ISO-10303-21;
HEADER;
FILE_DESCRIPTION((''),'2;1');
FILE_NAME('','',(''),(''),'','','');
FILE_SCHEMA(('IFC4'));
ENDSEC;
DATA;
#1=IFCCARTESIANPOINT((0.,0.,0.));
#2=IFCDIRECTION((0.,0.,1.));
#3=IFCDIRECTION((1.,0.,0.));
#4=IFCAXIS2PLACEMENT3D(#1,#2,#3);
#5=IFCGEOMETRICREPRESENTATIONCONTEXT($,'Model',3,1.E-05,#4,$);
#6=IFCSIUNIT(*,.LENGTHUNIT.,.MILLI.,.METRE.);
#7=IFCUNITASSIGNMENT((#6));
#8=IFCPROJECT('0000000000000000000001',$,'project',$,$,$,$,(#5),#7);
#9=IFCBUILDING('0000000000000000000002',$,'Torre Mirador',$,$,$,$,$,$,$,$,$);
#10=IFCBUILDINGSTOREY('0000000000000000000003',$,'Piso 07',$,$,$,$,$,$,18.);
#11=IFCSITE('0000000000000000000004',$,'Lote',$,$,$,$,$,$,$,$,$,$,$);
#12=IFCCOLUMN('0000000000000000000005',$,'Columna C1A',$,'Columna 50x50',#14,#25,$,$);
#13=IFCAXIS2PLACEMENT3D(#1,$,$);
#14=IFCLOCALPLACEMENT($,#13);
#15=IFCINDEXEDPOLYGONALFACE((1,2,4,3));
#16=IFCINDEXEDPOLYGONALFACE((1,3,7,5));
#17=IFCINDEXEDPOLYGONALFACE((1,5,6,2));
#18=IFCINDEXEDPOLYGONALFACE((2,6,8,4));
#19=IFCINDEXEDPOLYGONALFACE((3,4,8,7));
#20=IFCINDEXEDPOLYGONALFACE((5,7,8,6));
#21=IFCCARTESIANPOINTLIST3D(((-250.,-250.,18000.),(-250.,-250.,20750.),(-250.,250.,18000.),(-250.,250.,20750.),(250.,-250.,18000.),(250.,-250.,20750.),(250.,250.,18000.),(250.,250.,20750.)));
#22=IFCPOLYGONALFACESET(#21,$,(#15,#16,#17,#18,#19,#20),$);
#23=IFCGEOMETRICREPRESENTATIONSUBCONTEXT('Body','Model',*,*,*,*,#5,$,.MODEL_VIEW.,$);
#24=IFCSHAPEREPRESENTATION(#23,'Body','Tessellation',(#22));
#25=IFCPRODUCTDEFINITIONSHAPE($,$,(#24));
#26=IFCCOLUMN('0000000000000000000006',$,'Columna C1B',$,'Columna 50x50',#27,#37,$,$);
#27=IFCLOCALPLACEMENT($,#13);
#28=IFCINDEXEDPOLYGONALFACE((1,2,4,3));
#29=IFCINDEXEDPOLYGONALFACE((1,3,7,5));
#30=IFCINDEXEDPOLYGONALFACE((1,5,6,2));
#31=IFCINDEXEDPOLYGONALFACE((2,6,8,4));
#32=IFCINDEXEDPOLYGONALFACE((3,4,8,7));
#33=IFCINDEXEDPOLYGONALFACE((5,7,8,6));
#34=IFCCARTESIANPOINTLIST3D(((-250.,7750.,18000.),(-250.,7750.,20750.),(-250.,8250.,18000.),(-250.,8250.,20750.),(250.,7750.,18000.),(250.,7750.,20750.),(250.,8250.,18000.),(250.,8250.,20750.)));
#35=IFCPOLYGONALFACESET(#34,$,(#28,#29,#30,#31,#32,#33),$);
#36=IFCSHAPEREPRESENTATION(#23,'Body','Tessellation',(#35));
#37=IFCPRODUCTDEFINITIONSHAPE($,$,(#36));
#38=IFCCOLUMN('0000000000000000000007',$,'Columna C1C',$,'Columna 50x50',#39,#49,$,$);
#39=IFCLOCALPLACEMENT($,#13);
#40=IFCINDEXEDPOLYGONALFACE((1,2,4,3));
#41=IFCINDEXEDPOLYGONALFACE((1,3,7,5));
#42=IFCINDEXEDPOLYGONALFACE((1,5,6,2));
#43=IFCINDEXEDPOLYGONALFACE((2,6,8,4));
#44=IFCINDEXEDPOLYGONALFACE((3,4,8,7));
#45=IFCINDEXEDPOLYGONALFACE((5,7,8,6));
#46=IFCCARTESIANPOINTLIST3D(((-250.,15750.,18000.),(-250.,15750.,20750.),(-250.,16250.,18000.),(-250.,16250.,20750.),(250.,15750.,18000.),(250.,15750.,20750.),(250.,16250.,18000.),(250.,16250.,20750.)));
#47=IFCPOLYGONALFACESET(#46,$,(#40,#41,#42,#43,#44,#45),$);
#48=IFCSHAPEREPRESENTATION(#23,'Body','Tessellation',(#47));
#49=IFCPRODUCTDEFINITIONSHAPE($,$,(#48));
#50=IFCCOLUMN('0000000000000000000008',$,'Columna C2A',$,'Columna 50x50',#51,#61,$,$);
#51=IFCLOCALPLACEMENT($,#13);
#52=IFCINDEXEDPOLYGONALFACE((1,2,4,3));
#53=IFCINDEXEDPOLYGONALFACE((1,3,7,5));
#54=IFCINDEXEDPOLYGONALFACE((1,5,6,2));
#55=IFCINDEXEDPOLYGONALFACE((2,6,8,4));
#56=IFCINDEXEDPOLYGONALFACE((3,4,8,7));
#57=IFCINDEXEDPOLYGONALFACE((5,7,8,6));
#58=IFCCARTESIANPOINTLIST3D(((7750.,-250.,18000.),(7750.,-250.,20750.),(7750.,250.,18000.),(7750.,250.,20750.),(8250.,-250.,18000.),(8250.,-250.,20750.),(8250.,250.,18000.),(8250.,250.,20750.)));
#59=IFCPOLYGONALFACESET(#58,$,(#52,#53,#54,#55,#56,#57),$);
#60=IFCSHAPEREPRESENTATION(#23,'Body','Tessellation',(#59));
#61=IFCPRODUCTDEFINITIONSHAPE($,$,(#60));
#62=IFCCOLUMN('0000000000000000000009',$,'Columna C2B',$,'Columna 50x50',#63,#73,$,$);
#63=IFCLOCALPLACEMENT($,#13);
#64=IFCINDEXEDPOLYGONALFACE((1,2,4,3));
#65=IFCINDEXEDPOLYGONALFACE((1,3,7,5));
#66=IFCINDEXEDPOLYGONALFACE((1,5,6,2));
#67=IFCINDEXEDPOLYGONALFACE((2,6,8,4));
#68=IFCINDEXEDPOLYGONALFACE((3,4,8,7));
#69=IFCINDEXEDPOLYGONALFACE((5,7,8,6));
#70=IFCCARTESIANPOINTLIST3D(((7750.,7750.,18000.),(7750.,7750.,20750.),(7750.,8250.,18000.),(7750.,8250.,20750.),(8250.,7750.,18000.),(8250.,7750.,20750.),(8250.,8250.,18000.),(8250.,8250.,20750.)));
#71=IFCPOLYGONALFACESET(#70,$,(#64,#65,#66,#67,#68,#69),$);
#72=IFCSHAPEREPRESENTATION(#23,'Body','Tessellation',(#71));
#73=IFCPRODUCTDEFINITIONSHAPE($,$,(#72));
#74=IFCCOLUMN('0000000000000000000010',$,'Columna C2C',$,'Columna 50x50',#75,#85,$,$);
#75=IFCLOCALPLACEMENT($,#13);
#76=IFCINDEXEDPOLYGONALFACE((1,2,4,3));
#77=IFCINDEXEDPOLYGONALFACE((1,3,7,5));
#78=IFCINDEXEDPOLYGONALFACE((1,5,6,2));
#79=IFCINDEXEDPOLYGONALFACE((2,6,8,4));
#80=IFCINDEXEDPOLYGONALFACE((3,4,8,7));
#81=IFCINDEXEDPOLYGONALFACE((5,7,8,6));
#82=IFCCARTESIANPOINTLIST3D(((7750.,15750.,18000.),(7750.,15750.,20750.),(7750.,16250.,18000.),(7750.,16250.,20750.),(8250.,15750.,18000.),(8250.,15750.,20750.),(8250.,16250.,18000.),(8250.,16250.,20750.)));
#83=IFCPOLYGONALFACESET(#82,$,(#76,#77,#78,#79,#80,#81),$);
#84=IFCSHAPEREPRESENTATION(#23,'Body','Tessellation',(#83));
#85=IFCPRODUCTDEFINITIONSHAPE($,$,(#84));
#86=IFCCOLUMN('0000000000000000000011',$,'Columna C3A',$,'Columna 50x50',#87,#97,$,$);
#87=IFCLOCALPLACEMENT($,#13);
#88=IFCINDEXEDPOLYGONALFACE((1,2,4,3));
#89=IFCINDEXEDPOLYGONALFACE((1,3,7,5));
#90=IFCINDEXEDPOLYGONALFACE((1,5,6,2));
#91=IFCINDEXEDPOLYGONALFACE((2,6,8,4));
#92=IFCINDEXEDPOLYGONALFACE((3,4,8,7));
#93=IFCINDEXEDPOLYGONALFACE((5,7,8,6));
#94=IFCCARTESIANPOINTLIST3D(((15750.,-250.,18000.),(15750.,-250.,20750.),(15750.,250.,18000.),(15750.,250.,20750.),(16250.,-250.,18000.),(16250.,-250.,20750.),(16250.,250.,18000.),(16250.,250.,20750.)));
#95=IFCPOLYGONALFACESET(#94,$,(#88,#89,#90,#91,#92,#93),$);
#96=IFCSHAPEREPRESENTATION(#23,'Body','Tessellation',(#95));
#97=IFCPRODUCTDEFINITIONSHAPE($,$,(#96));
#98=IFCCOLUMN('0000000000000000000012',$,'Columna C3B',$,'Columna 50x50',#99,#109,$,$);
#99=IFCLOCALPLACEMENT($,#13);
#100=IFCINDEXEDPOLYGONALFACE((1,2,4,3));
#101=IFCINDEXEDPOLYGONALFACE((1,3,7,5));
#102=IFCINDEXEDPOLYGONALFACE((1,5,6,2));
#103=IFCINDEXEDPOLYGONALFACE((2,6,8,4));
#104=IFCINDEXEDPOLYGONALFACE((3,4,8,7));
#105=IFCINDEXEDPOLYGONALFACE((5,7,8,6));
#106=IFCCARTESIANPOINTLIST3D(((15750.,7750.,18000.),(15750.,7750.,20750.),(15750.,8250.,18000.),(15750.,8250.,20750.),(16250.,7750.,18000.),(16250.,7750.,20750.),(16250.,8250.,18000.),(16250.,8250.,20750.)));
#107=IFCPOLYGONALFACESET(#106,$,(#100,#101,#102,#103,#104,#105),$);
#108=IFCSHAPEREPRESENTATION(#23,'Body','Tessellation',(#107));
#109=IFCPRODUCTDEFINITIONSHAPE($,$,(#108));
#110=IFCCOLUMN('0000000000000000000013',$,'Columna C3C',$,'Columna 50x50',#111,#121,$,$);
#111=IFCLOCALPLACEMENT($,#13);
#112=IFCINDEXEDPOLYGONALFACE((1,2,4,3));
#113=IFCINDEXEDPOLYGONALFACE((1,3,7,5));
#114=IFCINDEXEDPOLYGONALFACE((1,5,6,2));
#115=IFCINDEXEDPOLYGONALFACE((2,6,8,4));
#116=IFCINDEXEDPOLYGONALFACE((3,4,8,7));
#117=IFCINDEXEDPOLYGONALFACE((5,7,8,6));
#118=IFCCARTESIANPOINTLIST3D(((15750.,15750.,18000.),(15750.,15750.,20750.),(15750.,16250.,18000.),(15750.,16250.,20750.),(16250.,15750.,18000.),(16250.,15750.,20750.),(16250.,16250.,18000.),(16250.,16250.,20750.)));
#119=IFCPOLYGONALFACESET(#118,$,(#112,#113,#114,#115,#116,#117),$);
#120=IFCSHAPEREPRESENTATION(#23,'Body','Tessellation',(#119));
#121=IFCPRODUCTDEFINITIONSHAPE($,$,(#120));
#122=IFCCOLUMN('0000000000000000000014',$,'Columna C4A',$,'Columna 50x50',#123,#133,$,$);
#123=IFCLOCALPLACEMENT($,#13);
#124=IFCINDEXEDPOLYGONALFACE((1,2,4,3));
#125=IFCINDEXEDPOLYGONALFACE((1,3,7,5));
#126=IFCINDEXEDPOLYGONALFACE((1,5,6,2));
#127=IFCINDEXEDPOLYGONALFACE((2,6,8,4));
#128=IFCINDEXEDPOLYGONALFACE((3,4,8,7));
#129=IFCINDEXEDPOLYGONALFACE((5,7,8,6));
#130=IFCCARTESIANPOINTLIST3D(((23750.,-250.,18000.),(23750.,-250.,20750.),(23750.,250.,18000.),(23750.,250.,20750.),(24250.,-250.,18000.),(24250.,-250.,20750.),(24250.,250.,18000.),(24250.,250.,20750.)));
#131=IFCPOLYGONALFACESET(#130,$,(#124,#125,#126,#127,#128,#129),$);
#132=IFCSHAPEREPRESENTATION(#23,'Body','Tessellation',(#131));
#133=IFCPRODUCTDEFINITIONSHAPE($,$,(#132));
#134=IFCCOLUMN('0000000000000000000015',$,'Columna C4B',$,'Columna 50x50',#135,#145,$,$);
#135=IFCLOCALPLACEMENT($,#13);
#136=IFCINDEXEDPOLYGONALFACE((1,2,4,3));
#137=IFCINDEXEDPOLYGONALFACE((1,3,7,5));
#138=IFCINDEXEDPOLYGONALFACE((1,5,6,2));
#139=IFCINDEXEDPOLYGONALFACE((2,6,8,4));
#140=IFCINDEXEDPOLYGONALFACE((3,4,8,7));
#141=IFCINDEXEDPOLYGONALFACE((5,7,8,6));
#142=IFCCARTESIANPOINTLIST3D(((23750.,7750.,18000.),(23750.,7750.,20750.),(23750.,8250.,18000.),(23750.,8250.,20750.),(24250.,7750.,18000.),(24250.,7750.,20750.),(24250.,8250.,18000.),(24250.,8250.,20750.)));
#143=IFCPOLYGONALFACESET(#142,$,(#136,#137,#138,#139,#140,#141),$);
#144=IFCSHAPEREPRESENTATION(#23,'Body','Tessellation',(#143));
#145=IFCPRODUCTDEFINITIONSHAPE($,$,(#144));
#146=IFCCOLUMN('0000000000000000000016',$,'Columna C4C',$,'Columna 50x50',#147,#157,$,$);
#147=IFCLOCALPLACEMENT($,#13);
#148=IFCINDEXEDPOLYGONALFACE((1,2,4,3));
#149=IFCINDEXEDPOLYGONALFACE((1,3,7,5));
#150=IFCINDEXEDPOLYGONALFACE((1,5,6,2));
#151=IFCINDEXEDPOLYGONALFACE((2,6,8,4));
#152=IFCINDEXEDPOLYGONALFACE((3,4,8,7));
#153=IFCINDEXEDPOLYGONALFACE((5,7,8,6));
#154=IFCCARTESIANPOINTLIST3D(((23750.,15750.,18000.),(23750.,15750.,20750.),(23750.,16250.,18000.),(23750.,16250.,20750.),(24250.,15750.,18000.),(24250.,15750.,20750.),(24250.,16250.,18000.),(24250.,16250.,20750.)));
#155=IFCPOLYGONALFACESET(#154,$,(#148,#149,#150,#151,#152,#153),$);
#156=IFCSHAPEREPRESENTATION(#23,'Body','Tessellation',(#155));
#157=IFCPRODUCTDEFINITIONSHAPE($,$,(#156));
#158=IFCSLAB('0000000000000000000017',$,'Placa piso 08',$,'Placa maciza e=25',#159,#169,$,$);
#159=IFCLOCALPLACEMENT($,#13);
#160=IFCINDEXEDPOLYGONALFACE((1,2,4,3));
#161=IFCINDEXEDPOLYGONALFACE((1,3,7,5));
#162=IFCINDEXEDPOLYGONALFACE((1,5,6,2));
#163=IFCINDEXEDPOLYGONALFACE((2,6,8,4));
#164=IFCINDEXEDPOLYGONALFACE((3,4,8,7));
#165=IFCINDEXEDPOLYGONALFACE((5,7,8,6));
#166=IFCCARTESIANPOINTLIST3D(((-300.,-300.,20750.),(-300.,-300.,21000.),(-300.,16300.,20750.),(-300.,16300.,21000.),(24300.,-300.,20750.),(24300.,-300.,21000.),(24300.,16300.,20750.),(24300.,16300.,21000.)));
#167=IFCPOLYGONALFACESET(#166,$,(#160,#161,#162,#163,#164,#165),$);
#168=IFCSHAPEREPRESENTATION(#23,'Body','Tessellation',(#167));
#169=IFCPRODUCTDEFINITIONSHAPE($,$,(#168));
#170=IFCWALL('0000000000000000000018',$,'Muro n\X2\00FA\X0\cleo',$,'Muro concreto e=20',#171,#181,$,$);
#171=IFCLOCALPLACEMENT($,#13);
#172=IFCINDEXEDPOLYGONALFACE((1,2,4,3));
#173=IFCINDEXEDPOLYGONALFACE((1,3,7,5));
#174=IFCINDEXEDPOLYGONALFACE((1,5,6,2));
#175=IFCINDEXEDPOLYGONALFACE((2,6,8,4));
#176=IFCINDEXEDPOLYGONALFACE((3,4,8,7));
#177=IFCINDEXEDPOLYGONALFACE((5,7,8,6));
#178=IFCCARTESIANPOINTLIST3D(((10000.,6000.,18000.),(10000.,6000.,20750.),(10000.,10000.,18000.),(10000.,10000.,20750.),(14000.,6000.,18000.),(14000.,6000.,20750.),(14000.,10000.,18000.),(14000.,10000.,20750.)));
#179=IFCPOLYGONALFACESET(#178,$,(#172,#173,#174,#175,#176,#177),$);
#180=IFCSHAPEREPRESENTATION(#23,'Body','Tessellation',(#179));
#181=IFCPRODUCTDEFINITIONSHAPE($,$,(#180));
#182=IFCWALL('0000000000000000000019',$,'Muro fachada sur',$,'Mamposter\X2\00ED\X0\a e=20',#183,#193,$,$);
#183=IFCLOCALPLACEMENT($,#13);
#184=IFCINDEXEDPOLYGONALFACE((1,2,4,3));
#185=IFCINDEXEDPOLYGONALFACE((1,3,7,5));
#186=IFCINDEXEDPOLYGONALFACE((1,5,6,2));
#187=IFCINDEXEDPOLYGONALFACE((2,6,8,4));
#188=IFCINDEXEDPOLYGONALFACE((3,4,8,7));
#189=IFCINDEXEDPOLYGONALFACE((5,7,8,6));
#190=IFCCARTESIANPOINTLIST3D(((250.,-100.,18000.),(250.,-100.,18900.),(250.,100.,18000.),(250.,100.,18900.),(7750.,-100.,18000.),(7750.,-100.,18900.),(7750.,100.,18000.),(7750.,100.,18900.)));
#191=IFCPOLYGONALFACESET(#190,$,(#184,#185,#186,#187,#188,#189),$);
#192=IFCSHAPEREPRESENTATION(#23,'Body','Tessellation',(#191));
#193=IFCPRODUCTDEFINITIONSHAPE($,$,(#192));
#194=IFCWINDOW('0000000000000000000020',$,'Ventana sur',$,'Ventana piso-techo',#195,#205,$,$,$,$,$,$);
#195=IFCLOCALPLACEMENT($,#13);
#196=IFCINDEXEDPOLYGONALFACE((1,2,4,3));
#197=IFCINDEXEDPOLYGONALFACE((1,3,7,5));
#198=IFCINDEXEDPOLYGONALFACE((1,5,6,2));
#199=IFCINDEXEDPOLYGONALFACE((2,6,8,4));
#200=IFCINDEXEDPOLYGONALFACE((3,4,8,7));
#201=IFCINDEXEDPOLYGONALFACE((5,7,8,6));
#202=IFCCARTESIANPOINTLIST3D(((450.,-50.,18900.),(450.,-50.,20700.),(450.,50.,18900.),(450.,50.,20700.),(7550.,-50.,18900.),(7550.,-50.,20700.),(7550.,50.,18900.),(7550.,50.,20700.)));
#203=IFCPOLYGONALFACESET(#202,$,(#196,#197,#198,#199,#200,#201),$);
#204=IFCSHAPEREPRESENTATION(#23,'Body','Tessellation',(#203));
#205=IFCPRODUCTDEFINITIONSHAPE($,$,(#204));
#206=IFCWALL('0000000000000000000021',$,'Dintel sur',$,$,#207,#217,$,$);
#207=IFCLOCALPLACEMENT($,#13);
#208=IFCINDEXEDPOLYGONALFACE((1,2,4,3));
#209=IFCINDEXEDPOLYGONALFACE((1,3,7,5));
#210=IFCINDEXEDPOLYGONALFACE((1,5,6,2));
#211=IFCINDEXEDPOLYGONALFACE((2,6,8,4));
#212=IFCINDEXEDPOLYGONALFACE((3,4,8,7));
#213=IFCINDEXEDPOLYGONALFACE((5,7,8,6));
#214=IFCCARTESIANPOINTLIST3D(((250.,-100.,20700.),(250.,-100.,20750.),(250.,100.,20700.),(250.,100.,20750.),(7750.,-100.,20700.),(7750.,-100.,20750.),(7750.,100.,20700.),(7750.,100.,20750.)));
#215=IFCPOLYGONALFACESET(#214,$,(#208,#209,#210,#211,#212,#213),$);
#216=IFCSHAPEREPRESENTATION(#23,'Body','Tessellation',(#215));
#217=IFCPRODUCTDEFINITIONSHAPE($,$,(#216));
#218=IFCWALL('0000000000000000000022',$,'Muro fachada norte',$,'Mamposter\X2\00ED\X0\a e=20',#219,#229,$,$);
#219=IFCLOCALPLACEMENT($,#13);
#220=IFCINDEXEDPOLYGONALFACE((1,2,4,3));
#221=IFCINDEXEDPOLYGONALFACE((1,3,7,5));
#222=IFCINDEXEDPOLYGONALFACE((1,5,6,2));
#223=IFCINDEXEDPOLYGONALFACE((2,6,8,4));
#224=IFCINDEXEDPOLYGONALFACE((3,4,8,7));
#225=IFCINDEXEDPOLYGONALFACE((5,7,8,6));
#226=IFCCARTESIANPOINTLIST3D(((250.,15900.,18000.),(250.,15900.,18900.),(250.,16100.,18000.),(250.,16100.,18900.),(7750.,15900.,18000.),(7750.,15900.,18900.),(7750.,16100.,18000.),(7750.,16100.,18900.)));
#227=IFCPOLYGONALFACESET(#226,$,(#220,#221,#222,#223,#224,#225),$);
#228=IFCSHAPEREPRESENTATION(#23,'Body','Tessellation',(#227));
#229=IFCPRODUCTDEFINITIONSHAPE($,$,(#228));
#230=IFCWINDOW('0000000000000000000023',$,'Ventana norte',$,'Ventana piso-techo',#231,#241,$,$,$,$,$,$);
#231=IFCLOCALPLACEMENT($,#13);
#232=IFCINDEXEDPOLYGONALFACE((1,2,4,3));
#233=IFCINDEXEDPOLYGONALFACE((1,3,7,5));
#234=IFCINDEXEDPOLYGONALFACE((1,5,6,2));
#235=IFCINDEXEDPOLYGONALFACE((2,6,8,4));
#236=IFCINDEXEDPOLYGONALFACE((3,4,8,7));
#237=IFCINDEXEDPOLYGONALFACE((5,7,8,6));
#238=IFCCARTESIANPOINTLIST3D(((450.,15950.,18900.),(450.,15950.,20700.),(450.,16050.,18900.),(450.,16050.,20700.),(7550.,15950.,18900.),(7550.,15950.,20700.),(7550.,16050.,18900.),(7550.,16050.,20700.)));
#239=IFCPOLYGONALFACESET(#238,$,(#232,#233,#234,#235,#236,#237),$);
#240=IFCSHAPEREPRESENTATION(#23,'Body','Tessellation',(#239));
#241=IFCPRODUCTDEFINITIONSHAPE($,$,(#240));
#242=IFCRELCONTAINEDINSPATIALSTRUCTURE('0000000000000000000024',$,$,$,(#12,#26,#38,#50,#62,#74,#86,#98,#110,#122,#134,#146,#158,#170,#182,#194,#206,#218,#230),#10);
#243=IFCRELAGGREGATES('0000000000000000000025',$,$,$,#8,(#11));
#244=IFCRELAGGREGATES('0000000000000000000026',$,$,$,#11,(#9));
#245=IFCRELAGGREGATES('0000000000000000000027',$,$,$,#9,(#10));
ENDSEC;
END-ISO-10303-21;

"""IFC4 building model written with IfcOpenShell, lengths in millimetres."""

from ifc_helpers import new_model, si_unit, frame, origin_with_axes, place, context, subcontext, project, spatial, indexed_curve, outline, extrude, element, save


model = new_model("IFC4")

# Units and contexts
model_context = context("Model", 3, precision=1e-05, world=origin_with_axes())
body_context = subcontext(model_context, "Body", "Model", "MODEL_VIEW")
ifc_project = project(units=[si_unit("LENGTHUNIT", "METRE", prefix="MILLI")], contexts=[model_context])

# Site, building, storey
site = spatial("IfcSite", under=ifc_project, Name="Lote")
building = spatial("IfcBuilding", under=site, Name="Torre Mirador")
storey = spatial("IfcBuildingStorey", under=building, Name="Piso 07", Elevation=18.0)

# Columns
for number, where, z_axis, x_axis, name in (
    (1, (-250.0, -250.0, 18000.0), (0.0, 0.0, 1.0), (1.0, 0.0, 0.0), "Columna C1A"),
    (2, (-250.0, 7750.0, 18000.0), (0.0, 0.0, 1.0), (1.0, 0.0, 0.0), "Columna C1B"),
    (3, (-250.0, 15750.0, 18000.0), (0.0, 0.0, 1.0), (1.0, 0.0, 0.0), "Columna C1C"),
    (4, (7750.0, -250.0, 18000.0), (0.0, 0.0, 1.0), (1.0, 0.0, 0.0), "Columna C2A"),
    (5, (7750.0, 7750.0, 18000.0), (0.0, 0.0, 1.0), (1.0, 0.0, 0.0), "Columna C2B"),
    (6, (7750.0, 15750.0, 18000.0), (0.0, 0.0, 1.0), (1.0, 0.0, 0.0), "Columna C2C"),
    (7, (15750.0, -250.0, 18000.0), (0.0, 0.0, 1.0), (1.0, 0.0, 0.0), "Columna C3A"),
    (8, (15750.0, 7750.0, 18000.0), (0.0, 0.0, 1.0), (1.0, 0.0, 0.0), "Columna C3B"),
    (9, (15750.0, 15750.0, 18000.0), (0.0, 0.0, 1.0), (1.0, 0.0, 0.0), "Columna C3C"),
    (10, (23750.0, -250.0, 18000.0), (0.0, 0.0, 1.0), (1.0, 0.0, 0.0), "Columna C4A"),
    (11, (23750.0, 7750.0, 18000.0), (0.0, 0.0, 1.0), (1.0, 0.0, 0.0), "Columna C4B"),
    (12, (23750.0, 15750.0, 18000.0), (0.0, 0.0, 1.0), (1.0, 0.0, 0.0), "Columna C4C"),
):
    element("IfcColumn", number, at=place(None, frame(where, z_axis=z_axis, x_axis=x_axis)), inside=storey, Name=name, ObjectType="Columna 50x50", context=body_context, shape_type="SweptSolid", body=[
        extrude(outline(indexed_curve([(0.0, 0.0), (0.0, 500.0), (500.0, 500.0), (500.0, 0.0), (0.0, 0.0)], self_intersect=False)), origin_with_axes(), (0.0, 0.0, 1.0), 2750.0),
    ])

# Slab
slab_placement = place(None, frame((-300.0, -300.0, 20750.0), z_axis=(0.0, 0.0, 1.0), x_axis=(1.0, 0.0, 0.0)))
element("IfcSlab", 13, at=slab_placement, inside=storey, Name="Placa piso 08", ObjectType="Placa maciza e=25", context=body_context, shape_type="SweptSolid", body=[
    extrude(outline(indexed_curve([(0.0, 0.0), (0.0, 16600.0), (24600.0, 16600.0), (24600.0, 0.0), (0.0, 0.0)], self_intersect=False)), origin_with_axes(), (0.0, 0.0, 1.0), 250.0),
])

# Walls
wall_1_placement = place(None, frame((10000.0, 6000.0, 18000.0), z_axis=(0.0, 0.0, 1.0), x_axis=(1.0, 0.0, 0.0)))
element("IfcWall", 14, at=wall_1_placement, inside=storey, Name="Muro núcleo", ObjectType="Muro concreto e=20", context=body_context, shape_type="SweptSolid", body=[
    extrude(outline(indexed_curve([(0.0, 0.0), (0.0, 4000.0), (4000.0, 4000.0), (4000.0, 0.0), (0.0, 0.0)], self_intersect=False)), origin_with_axes(), (0.0, 0.0, 1.0), 2750.0),
])
wall_2_placement = place(None, frame((250.0, -100.0, 18000.0), z_axis=(0.0, 0.0, 1.0), x_axis=(1.0, 0.0, 0.0)))
element("IfcWall", 15, at=wall_2_placement, inside=storey, Name="Muro fachada sur", ObjectType="Mampostería e=20", context=body_context, shape_type="SweptSolid", body=[
    extrude(outline(indexed_curve([(0.0, 0.0), (0.0, 200.0), (7500.0, 200.0), (7500.0, 0.0), (0.0, 0.0)], self_intersect=False)), origin_with_axes(), (0.0, 0.0, 1.0), 900.0),
])

# Window
window_1_placement = place(None, frame((450.0, -50.0, 18900.0), z_axis=(0.0, 0.0, 1.0), x_axis=(1.0, 0.0, 0.0)))
element("IfcWindow", 16, at=window_1_placement, inside=storey, Name="Ventana sur", ObjectType="Ventana piso-techo", context=body_context, shape_type="SweptSolid", body=[
    extrude(outline(indexed_curve([(0.0, 0.0), (0.0, 100.0), (7100.0, 100.0), (7100.0, 0.0), (0.0, 0.0)], self_intersect=False)), origin_with_axes(), (0.0, 0.0, 1.0), 1800.0),
])

# Walls
wall_3_placement = place(None, frame((250.0, -100.0, 20700.0), z_axis=(0.0, 0.0, 1.0), x_axis=(1.0, 0.0, 0.0)))
element("IfcWall", 17, at=wall_3_placement, inside=storey, Name="Dintel sur", context=body_context, shape_type="SweptSolid", body=[
    extrude(outline(indexed_curve([(0.0, 0.0), (0.0, 200.0), (7500.0, 200.0), (7500.0, 0.0), (0.0, 0.0)], self_intersect=False)), origin_with_axes(), (0.0, 0.0, 1.0), 50.0),
])
wall_4_placement = place(None, frame((250.0, 15900.0, 18000.0), z_axis=(0.0, 0.0, 1.0), x_axis=(1.0, 0.0, 0.0)))
element("IfcWall", 18, at=wall_4_placement, inside=storey, Name="Muro fachada norte", ObjectType="Mampostería e=20", context=body_context, shape_type="SweptSolid", body=[
    extrude(outline(indexed_curve([(0.0, 0.0), (0.0, 200.0), (7500.0, 200.0), (7500.0, 0.0), (0.0, 0.0)], self_intersect=False)), origin_with_axes(), (0.0, 0.0, 1.0), 900.0),
])

# Window
window_2_placement = place(None, frame((450.0, 15950.0, 18900.0), z_axis=(0.0, 0.0, 1.0), x_axis=(1.0, 0.0, 0.0)))
element("IfcWindow", 19, at=window_2_placement, inside=storey, Name="Ventana norte", ObjectType="Ventana piso-techo", context=body_context, shape_type="SweptSolid", body=[
    extrude(outline(indexed_curve([(0.0, 0.0), (0.0, 100.0), (7100.0, 100.0), (7100.0, 0.0), (0.0, 0.0)], self_intersect=False)), origin_with_axes(), (0.0, 0.0, 1.0), 1800.0),
])

save(model, "model.ifc")
